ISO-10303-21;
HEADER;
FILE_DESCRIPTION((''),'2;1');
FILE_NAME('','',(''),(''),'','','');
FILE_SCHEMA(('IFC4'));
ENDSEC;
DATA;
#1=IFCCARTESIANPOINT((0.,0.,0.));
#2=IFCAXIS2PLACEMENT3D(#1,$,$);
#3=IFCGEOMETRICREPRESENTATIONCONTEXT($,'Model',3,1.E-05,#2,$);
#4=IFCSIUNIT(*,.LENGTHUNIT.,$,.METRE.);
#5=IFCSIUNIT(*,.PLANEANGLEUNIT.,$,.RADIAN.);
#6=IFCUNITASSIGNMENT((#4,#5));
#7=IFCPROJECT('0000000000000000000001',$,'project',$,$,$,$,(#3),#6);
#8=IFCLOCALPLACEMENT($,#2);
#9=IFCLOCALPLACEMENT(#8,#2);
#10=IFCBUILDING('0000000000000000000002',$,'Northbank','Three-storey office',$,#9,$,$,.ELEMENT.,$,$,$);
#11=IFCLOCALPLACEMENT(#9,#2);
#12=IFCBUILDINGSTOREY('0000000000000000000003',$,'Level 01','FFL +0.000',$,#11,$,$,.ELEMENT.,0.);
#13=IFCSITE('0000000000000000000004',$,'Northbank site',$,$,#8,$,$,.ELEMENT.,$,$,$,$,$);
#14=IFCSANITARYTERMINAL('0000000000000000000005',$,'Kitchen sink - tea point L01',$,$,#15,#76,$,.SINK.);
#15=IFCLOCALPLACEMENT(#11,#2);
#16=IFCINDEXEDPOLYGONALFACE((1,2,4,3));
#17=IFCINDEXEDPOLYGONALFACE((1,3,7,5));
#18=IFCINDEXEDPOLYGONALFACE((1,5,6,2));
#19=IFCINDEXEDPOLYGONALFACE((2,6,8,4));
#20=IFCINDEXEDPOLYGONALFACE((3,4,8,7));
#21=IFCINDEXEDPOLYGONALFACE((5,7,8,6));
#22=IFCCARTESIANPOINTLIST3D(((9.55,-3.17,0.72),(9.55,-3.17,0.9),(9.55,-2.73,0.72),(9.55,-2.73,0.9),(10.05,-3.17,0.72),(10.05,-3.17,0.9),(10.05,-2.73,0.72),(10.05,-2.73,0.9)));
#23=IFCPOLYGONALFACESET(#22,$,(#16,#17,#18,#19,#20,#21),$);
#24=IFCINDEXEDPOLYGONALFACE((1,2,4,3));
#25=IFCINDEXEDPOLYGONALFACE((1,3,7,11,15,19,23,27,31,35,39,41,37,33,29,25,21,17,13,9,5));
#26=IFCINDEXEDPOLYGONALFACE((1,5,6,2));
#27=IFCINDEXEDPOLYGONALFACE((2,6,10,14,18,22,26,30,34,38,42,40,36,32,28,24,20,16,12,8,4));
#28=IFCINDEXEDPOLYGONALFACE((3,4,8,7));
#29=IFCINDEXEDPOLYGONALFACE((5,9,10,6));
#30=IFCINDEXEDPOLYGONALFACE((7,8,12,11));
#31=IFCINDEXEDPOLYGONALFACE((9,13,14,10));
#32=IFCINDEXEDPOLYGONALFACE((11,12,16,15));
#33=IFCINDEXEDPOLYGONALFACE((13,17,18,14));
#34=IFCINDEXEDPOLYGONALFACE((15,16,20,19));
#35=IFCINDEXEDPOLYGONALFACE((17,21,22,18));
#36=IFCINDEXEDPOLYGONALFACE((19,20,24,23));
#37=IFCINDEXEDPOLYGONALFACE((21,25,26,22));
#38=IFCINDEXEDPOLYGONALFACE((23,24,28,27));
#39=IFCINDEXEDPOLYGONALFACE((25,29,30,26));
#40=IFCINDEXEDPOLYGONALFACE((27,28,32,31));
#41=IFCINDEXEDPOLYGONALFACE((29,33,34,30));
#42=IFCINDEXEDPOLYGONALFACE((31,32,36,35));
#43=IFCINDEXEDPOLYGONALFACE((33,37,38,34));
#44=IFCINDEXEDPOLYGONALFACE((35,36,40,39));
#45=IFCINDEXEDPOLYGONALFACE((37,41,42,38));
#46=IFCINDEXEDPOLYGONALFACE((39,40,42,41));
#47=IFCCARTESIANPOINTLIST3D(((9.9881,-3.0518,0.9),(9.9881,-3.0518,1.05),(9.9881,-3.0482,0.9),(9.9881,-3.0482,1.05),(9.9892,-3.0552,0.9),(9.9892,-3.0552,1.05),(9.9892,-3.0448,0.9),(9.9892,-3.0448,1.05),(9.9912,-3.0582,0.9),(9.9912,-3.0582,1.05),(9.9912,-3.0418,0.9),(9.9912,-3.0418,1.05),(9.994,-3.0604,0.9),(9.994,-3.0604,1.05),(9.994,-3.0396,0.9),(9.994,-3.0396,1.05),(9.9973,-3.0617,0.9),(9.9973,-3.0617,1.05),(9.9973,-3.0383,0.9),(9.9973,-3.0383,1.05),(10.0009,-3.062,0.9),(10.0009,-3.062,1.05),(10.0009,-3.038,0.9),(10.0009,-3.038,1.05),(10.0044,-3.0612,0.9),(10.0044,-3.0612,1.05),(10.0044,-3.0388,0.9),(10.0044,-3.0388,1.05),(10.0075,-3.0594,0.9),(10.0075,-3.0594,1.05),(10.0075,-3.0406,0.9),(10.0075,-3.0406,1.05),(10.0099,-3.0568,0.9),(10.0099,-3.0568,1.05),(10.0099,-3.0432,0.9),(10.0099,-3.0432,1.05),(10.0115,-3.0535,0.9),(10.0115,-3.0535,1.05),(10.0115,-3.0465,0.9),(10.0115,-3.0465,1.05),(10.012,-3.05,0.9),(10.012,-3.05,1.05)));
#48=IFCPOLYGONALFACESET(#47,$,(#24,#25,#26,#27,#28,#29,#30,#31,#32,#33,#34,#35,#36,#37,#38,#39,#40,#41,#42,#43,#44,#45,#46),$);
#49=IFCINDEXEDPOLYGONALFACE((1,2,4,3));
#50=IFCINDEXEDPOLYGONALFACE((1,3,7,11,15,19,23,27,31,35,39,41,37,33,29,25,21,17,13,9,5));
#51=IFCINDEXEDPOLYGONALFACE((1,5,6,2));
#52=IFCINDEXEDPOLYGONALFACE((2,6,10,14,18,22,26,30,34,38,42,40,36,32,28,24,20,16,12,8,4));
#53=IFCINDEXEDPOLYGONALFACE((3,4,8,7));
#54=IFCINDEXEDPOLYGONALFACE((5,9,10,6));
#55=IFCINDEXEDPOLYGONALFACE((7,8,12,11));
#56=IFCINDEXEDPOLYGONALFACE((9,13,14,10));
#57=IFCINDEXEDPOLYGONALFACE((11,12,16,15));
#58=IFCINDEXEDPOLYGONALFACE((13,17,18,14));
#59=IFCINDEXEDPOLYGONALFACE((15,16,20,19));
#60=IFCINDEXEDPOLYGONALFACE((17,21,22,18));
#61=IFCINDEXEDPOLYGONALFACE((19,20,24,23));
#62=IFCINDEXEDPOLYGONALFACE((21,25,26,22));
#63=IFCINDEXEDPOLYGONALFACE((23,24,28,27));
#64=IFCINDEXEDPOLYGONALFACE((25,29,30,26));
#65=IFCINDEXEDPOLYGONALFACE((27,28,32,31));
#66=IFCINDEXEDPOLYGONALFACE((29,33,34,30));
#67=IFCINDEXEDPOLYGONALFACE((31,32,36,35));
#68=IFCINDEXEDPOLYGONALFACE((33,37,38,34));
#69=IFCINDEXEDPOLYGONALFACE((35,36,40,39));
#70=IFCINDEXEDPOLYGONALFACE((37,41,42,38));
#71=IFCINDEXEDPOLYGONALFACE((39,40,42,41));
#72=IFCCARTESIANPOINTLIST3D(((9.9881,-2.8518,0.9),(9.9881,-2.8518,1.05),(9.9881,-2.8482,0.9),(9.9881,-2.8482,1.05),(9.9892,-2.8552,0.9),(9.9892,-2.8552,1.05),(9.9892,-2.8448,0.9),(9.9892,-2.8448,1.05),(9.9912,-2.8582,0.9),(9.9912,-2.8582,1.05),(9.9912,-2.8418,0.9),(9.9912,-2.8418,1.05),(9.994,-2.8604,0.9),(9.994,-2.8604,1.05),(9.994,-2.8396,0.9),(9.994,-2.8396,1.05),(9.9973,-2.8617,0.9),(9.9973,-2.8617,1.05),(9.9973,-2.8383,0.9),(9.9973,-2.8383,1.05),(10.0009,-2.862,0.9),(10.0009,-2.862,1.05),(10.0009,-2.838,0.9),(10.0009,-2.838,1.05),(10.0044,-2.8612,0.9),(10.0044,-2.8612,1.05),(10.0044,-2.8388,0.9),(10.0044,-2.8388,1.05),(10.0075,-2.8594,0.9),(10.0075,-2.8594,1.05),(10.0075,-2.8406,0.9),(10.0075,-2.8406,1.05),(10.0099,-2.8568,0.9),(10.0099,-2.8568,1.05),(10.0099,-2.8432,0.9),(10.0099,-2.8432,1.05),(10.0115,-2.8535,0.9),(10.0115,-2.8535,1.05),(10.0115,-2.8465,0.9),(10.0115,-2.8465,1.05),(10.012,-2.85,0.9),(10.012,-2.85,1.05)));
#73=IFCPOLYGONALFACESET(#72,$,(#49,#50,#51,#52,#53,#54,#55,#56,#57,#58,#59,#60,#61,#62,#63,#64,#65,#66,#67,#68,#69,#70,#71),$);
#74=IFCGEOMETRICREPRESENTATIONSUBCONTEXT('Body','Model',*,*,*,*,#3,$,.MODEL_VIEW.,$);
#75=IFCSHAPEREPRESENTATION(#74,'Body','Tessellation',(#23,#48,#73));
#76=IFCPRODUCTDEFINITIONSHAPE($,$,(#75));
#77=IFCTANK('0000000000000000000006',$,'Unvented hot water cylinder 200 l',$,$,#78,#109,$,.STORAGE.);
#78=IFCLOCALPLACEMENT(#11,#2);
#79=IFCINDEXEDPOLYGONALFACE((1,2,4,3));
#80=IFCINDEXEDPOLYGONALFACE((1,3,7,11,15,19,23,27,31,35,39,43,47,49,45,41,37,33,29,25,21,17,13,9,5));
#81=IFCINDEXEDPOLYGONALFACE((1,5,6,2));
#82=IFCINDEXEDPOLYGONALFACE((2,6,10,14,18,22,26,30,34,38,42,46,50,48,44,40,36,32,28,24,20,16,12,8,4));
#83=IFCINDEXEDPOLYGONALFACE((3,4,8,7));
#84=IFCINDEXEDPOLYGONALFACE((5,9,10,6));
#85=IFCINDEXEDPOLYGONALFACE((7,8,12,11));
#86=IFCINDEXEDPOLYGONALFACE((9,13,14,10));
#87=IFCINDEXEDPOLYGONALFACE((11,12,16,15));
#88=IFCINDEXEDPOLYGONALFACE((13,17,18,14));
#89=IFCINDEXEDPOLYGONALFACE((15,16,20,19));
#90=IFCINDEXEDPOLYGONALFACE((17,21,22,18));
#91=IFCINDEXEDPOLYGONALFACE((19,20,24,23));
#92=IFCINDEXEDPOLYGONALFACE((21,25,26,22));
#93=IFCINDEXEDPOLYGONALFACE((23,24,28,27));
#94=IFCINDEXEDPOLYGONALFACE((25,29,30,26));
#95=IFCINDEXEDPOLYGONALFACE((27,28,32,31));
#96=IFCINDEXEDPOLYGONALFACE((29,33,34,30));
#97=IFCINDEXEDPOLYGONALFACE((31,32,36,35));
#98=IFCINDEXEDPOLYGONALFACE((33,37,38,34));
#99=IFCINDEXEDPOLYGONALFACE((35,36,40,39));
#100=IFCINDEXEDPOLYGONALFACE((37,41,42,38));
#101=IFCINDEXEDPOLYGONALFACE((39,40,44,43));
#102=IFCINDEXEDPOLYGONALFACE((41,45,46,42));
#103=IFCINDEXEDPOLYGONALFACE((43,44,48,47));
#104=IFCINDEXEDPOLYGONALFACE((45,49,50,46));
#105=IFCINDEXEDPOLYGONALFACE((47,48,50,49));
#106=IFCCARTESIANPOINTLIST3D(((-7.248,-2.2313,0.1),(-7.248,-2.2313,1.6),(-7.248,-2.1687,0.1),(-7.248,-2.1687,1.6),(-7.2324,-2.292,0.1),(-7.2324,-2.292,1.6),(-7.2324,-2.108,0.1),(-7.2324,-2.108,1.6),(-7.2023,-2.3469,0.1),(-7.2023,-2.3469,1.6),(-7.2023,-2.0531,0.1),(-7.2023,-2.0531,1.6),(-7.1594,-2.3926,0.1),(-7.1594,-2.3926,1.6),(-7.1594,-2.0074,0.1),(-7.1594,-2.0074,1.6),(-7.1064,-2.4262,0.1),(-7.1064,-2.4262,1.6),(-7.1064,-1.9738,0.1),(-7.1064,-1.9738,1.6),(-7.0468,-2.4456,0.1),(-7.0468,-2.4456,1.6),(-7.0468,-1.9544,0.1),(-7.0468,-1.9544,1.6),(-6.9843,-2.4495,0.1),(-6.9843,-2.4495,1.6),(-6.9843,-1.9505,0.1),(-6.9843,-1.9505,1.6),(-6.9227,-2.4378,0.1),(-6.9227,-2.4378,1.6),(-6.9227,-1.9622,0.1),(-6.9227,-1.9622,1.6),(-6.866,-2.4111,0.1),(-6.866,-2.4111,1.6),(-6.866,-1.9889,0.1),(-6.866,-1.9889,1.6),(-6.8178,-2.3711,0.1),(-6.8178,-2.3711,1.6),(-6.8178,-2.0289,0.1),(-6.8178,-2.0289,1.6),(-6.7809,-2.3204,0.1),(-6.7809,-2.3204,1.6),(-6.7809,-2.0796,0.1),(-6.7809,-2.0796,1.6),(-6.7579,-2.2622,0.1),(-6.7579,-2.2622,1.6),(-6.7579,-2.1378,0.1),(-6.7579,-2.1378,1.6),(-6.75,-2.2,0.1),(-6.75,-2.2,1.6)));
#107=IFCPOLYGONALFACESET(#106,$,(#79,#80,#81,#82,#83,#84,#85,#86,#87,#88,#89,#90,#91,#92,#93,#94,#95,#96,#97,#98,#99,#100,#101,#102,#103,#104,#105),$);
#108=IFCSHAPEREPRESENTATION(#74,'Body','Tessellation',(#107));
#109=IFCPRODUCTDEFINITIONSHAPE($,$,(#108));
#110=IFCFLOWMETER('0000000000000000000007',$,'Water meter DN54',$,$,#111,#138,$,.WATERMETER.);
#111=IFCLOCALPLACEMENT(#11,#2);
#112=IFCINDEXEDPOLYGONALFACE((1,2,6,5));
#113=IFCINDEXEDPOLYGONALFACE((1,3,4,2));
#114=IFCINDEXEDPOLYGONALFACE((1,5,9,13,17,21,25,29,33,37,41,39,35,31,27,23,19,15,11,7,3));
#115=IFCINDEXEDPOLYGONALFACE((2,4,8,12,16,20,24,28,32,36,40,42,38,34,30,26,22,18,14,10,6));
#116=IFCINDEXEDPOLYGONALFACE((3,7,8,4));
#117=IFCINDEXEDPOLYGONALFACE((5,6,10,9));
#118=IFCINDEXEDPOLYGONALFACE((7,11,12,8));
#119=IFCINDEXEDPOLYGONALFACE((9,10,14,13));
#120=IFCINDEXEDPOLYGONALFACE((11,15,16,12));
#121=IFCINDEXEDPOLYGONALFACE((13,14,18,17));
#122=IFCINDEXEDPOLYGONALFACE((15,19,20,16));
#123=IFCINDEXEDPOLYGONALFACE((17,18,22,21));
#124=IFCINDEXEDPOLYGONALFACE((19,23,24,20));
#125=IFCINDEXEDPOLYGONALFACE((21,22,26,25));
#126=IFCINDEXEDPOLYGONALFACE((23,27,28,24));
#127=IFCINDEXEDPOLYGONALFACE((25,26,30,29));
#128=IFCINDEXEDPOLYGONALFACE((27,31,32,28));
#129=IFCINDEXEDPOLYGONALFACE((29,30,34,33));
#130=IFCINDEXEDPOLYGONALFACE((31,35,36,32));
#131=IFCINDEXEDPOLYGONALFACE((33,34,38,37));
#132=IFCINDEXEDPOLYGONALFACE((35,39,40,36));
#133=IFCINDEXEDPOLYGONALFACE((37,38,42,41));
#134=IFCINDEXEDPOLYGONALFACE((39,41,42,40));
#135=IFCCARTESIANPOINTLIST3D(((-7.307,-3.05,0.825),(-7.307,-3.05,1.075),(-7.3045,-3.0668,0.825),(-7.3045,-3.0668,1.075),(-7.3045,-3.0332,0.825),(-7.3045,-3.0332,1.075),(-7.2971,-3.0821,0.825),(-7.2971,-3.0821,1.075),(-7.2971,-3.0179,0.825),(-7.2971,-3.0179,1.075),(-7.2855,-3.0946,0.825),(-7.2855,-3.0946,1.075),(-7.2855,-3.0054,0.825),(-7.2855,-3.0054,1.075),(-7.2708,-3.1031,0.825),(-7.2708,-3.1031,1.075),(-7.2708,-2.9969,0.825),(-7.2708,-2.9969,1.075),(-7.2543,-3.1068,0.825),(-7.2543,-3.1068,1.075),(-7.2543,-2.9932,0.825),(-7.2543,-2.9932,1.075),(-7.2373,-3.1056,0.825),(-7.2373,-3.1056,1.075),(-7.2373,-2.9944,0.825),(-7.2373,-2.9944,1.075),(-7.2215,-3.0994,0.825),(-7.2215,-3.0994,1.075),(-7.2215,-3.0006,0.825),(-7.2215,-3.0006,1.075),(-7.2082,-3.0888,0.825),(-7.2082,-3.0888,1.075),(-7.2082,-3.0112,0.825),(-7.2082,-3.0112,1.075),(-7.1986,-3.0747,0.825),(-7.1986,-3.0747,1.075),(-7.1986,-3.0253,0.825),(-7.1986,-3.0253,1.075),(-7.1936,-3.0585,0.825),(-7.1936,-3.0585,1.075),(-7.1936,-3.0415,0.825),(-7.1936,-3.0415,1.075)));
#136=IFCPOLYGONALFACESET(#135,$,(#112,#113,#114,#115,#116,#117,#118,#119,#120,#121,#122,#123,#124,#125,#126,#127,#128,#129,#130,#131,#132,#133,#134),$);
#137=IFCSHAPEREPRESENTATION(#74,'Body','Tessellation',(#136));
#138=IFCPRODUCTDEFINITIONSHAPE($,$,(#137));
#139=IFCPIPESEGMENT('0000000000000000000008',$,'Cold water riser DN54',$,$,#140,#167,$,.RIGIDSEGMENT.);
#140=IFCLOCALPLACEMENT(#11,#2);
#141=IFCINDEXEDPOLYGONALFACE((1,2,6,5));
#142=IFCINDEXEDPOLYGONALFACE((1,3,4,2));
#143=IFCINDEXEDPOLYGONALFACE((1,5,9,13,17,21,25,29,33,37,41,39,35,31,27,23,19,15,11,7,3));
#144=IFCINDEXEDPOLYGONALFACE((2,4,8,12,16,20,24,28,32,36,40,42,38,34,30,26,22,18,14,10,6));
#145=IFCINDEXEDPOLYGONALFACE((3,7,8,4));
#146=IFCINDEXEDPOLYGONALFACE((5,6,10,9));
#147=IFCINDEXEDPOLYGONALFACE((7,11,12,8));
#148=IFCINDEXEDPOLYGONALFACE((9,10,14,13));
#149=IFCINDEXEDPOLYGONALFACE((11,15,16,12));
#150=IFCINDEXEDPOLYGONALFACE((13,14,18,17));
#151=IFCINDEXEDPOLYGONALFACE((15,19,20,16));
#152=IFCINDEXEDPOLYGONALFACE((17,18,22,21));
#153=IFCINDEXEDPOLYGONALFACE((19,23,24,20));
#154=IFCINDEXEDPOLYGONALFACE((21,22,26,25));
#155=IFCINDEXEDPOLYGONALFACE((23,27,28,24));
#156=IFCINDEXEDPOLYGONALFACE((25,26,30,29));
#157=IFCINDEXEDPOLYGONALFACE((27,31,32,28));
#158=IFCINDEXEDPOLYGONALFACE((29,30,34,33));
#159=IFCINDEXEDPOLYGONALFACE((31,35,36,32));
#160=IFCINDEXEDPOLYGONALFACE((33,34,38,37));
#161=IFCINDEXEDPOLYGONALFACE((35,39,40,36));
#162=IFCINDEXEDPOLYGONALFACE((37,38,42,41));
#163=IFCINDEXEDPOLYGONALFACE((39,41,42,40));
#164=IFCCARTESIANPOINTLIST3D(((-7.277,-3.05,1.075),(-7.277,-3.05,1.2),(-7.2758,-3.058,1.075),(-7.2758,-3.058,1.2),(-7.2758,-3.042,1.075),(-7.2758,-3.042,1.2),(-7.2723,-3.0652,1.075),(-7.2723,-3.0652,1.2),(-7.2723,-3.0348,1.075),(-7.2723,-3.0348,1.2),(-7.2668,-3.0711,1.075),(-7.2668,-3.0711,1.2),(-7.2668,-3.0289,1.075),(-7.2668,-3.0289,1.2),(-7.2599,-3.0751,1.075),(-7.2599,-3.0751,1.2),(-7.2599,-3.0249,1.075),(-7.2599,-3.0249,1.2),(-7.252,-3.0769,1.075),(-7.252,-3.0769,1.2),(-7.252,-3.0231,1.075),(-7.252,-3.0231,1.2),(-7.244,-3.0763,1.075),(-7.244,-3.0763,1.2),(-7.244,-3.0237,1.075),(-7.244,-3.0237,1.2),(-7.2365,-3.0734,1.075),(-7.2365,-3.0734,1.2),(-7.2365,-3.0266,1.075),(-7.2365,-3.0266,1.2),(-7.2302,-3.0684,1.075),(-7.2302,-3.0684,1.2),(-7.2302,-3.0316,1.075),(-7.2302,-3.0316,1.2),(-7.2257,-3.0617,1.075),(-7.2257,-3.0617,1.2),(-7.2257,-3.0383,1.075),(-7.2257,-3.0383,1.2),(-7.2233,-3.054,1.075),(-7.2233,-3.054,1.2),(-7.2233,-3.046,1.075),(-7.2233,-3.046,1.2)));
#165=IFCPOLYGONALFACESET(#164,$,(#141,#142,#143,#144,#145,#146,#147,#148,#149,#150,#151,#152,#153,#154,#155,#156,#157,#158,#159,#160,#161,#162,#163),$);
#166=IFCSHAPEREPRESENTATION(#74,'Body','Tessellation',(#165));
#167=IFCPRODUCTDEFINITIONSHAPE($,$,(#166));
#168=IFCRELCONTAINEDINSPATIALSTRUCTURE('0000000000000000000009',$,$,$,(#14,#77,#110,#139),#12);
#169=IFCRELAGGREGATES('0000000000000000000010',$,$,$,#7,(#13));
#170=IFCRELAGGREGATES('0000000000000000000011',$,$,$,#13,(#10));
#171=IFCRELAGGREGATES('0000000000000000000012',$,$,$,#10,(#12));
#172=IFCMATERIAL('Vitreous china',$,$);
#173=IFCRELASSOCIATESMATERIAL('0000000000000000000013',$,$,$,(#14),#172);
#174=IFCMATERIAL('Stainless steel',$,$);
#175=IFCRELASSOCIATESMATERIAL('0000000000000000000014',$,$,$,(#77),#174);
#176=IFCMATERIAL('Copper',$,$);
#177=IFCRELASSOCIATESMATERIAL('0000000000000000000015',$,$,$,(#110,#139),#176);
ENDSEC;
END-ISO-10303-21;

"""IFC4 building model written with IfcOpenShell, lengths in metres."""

from ifc_helpers import new_model, si_unit, frame, origin, place, context, subcontext, project, spatial, rectangle, circle, extrude, material, element, save


model = new_model("IFC4")

# Units and contexts
model_context = context("Model", 3, precision=1e-05, world=origin())
body_context = subcontext(model_context, "Body", "Model", "MODEL_VIEW")
ifc_project = project(units=[si_unit("LENGTHUNIT", "METRE"), si_unit("PLANEANGLEUNIT", "RADIAN")], contexts=[model_context])

# Site, building, storey
site_placement = place(None, origin())
site = spatial("IfcSite", under=ifc_project, at=site_placement, Name="Northbank site", CompositionType="ELEMENT")
building_placement = place(site_placement, origin())
building = spatial("IfcBuilding", under=site, at=building_placement, Name="Northbank", Description="Three-storey office", CompositionType="ELEMENT")
storey_placement = place(building_placement, origin())
storey = spatial("IfcBuildingStorey", under=building, at=storey_placement, Name="Level 01", Description="FFL +0.000", CompositionType="ELEMENT", Elevation=0.0)

# Sanitary terminal
ifc_material_1 = material(Name="Vitreous china")
sanitary_terminal_1_placement = place(storey_placement, origin())
element("IfcSanitaryTerminal", 1, at=sanitary_terminal_1_placement, inside=storey, material=ifc_material_1, Name="Kitchen sink - tea point L01", PredefinedType="SINK", context=body_context, shape_type="SweptSolid", body=[
    extrude(rectangle(XDim=0.5, YDim=0.44), frame((9.8, -2.95, 0.72)), (0.0, 0.0, 1.0), 0.18),
    extrude(circle(Radius=0.012), frame((10.0, -3.05, 0.9), z_axis=(0.0, 0.0, 1.0), x_axis=(1.0, 0.0, 0.0)), (0.0, 0.0, 1.0), 0.15),
    extrude(circle(Radius=0.012), frame((10.0, -2.85, 0.9), z_axis=(0.0, 0.0, 1.0), x_axis=(1.0, 0.0, 0.0)), (0.0, 0.0, 1.0), 0.15),
])

# Tank
ifc_material_2 = material(Name="Stainless steel")
tank_placement = place(storey_placement, origin())
element("IfcTank", 2, at=tank_placement, inside=storey, material=ifc_material_2, Name="Unvented hot water cylinder 200 l", PredefinedType="STORAGE", context=body_context, shape_type="SweptSolid", body=[
    extrude(circle(Radius=0.25), frame((-7.0, -2.2, 0.1), z_axis=(0.0, 0.0, 1.0), x_axis=(1.0, 0.0, 0.0)), (0.0, 0.0, 1.0), 1.5),
])

# Flow meter
ifc_material_3 = material(Name="Copper")
flow_meter_placement = place(storey_placement, origin())
element("IfcFlowMeter", 3, at=flow_meter_placement, inside=storey, material=ifc_material_3, Name="Water meter DN54", PredefinedType="WATERMETER", context=body_context, shape_type="SweptSolid", body=[
    extrude(circle(Radius=0.057), frame((-7.25, -3.05, 0.825), z_axis=(0.0, 0.0, 1.0), x_axis=(-1.0, 0.0, 0.0)), (0.0, 0.0, 1.0), 0.25),
])

# Pipe segment
pipe_segment_1_placement = place(storey_placement, origin())
element("IfcPipeSegment", 4, at=pipe_segment_1_placement, inside=storey, material=ifc_material_3, Name="Cold water riser DN54", PredefinedType="RIGIDSEGMENT", context=body_context, shape_type="SweptSolid", body=[
    extrude(circle(Radius=0.027), frame((-7.25, -3.05, 1.075), z_axis=(0.0, 0.0, 1.0), x_axis=(-1.0, 0.0, 0.0)), (0.0, 0.0, 1.0), 0.125),
])

save(model, "model.ifc")
